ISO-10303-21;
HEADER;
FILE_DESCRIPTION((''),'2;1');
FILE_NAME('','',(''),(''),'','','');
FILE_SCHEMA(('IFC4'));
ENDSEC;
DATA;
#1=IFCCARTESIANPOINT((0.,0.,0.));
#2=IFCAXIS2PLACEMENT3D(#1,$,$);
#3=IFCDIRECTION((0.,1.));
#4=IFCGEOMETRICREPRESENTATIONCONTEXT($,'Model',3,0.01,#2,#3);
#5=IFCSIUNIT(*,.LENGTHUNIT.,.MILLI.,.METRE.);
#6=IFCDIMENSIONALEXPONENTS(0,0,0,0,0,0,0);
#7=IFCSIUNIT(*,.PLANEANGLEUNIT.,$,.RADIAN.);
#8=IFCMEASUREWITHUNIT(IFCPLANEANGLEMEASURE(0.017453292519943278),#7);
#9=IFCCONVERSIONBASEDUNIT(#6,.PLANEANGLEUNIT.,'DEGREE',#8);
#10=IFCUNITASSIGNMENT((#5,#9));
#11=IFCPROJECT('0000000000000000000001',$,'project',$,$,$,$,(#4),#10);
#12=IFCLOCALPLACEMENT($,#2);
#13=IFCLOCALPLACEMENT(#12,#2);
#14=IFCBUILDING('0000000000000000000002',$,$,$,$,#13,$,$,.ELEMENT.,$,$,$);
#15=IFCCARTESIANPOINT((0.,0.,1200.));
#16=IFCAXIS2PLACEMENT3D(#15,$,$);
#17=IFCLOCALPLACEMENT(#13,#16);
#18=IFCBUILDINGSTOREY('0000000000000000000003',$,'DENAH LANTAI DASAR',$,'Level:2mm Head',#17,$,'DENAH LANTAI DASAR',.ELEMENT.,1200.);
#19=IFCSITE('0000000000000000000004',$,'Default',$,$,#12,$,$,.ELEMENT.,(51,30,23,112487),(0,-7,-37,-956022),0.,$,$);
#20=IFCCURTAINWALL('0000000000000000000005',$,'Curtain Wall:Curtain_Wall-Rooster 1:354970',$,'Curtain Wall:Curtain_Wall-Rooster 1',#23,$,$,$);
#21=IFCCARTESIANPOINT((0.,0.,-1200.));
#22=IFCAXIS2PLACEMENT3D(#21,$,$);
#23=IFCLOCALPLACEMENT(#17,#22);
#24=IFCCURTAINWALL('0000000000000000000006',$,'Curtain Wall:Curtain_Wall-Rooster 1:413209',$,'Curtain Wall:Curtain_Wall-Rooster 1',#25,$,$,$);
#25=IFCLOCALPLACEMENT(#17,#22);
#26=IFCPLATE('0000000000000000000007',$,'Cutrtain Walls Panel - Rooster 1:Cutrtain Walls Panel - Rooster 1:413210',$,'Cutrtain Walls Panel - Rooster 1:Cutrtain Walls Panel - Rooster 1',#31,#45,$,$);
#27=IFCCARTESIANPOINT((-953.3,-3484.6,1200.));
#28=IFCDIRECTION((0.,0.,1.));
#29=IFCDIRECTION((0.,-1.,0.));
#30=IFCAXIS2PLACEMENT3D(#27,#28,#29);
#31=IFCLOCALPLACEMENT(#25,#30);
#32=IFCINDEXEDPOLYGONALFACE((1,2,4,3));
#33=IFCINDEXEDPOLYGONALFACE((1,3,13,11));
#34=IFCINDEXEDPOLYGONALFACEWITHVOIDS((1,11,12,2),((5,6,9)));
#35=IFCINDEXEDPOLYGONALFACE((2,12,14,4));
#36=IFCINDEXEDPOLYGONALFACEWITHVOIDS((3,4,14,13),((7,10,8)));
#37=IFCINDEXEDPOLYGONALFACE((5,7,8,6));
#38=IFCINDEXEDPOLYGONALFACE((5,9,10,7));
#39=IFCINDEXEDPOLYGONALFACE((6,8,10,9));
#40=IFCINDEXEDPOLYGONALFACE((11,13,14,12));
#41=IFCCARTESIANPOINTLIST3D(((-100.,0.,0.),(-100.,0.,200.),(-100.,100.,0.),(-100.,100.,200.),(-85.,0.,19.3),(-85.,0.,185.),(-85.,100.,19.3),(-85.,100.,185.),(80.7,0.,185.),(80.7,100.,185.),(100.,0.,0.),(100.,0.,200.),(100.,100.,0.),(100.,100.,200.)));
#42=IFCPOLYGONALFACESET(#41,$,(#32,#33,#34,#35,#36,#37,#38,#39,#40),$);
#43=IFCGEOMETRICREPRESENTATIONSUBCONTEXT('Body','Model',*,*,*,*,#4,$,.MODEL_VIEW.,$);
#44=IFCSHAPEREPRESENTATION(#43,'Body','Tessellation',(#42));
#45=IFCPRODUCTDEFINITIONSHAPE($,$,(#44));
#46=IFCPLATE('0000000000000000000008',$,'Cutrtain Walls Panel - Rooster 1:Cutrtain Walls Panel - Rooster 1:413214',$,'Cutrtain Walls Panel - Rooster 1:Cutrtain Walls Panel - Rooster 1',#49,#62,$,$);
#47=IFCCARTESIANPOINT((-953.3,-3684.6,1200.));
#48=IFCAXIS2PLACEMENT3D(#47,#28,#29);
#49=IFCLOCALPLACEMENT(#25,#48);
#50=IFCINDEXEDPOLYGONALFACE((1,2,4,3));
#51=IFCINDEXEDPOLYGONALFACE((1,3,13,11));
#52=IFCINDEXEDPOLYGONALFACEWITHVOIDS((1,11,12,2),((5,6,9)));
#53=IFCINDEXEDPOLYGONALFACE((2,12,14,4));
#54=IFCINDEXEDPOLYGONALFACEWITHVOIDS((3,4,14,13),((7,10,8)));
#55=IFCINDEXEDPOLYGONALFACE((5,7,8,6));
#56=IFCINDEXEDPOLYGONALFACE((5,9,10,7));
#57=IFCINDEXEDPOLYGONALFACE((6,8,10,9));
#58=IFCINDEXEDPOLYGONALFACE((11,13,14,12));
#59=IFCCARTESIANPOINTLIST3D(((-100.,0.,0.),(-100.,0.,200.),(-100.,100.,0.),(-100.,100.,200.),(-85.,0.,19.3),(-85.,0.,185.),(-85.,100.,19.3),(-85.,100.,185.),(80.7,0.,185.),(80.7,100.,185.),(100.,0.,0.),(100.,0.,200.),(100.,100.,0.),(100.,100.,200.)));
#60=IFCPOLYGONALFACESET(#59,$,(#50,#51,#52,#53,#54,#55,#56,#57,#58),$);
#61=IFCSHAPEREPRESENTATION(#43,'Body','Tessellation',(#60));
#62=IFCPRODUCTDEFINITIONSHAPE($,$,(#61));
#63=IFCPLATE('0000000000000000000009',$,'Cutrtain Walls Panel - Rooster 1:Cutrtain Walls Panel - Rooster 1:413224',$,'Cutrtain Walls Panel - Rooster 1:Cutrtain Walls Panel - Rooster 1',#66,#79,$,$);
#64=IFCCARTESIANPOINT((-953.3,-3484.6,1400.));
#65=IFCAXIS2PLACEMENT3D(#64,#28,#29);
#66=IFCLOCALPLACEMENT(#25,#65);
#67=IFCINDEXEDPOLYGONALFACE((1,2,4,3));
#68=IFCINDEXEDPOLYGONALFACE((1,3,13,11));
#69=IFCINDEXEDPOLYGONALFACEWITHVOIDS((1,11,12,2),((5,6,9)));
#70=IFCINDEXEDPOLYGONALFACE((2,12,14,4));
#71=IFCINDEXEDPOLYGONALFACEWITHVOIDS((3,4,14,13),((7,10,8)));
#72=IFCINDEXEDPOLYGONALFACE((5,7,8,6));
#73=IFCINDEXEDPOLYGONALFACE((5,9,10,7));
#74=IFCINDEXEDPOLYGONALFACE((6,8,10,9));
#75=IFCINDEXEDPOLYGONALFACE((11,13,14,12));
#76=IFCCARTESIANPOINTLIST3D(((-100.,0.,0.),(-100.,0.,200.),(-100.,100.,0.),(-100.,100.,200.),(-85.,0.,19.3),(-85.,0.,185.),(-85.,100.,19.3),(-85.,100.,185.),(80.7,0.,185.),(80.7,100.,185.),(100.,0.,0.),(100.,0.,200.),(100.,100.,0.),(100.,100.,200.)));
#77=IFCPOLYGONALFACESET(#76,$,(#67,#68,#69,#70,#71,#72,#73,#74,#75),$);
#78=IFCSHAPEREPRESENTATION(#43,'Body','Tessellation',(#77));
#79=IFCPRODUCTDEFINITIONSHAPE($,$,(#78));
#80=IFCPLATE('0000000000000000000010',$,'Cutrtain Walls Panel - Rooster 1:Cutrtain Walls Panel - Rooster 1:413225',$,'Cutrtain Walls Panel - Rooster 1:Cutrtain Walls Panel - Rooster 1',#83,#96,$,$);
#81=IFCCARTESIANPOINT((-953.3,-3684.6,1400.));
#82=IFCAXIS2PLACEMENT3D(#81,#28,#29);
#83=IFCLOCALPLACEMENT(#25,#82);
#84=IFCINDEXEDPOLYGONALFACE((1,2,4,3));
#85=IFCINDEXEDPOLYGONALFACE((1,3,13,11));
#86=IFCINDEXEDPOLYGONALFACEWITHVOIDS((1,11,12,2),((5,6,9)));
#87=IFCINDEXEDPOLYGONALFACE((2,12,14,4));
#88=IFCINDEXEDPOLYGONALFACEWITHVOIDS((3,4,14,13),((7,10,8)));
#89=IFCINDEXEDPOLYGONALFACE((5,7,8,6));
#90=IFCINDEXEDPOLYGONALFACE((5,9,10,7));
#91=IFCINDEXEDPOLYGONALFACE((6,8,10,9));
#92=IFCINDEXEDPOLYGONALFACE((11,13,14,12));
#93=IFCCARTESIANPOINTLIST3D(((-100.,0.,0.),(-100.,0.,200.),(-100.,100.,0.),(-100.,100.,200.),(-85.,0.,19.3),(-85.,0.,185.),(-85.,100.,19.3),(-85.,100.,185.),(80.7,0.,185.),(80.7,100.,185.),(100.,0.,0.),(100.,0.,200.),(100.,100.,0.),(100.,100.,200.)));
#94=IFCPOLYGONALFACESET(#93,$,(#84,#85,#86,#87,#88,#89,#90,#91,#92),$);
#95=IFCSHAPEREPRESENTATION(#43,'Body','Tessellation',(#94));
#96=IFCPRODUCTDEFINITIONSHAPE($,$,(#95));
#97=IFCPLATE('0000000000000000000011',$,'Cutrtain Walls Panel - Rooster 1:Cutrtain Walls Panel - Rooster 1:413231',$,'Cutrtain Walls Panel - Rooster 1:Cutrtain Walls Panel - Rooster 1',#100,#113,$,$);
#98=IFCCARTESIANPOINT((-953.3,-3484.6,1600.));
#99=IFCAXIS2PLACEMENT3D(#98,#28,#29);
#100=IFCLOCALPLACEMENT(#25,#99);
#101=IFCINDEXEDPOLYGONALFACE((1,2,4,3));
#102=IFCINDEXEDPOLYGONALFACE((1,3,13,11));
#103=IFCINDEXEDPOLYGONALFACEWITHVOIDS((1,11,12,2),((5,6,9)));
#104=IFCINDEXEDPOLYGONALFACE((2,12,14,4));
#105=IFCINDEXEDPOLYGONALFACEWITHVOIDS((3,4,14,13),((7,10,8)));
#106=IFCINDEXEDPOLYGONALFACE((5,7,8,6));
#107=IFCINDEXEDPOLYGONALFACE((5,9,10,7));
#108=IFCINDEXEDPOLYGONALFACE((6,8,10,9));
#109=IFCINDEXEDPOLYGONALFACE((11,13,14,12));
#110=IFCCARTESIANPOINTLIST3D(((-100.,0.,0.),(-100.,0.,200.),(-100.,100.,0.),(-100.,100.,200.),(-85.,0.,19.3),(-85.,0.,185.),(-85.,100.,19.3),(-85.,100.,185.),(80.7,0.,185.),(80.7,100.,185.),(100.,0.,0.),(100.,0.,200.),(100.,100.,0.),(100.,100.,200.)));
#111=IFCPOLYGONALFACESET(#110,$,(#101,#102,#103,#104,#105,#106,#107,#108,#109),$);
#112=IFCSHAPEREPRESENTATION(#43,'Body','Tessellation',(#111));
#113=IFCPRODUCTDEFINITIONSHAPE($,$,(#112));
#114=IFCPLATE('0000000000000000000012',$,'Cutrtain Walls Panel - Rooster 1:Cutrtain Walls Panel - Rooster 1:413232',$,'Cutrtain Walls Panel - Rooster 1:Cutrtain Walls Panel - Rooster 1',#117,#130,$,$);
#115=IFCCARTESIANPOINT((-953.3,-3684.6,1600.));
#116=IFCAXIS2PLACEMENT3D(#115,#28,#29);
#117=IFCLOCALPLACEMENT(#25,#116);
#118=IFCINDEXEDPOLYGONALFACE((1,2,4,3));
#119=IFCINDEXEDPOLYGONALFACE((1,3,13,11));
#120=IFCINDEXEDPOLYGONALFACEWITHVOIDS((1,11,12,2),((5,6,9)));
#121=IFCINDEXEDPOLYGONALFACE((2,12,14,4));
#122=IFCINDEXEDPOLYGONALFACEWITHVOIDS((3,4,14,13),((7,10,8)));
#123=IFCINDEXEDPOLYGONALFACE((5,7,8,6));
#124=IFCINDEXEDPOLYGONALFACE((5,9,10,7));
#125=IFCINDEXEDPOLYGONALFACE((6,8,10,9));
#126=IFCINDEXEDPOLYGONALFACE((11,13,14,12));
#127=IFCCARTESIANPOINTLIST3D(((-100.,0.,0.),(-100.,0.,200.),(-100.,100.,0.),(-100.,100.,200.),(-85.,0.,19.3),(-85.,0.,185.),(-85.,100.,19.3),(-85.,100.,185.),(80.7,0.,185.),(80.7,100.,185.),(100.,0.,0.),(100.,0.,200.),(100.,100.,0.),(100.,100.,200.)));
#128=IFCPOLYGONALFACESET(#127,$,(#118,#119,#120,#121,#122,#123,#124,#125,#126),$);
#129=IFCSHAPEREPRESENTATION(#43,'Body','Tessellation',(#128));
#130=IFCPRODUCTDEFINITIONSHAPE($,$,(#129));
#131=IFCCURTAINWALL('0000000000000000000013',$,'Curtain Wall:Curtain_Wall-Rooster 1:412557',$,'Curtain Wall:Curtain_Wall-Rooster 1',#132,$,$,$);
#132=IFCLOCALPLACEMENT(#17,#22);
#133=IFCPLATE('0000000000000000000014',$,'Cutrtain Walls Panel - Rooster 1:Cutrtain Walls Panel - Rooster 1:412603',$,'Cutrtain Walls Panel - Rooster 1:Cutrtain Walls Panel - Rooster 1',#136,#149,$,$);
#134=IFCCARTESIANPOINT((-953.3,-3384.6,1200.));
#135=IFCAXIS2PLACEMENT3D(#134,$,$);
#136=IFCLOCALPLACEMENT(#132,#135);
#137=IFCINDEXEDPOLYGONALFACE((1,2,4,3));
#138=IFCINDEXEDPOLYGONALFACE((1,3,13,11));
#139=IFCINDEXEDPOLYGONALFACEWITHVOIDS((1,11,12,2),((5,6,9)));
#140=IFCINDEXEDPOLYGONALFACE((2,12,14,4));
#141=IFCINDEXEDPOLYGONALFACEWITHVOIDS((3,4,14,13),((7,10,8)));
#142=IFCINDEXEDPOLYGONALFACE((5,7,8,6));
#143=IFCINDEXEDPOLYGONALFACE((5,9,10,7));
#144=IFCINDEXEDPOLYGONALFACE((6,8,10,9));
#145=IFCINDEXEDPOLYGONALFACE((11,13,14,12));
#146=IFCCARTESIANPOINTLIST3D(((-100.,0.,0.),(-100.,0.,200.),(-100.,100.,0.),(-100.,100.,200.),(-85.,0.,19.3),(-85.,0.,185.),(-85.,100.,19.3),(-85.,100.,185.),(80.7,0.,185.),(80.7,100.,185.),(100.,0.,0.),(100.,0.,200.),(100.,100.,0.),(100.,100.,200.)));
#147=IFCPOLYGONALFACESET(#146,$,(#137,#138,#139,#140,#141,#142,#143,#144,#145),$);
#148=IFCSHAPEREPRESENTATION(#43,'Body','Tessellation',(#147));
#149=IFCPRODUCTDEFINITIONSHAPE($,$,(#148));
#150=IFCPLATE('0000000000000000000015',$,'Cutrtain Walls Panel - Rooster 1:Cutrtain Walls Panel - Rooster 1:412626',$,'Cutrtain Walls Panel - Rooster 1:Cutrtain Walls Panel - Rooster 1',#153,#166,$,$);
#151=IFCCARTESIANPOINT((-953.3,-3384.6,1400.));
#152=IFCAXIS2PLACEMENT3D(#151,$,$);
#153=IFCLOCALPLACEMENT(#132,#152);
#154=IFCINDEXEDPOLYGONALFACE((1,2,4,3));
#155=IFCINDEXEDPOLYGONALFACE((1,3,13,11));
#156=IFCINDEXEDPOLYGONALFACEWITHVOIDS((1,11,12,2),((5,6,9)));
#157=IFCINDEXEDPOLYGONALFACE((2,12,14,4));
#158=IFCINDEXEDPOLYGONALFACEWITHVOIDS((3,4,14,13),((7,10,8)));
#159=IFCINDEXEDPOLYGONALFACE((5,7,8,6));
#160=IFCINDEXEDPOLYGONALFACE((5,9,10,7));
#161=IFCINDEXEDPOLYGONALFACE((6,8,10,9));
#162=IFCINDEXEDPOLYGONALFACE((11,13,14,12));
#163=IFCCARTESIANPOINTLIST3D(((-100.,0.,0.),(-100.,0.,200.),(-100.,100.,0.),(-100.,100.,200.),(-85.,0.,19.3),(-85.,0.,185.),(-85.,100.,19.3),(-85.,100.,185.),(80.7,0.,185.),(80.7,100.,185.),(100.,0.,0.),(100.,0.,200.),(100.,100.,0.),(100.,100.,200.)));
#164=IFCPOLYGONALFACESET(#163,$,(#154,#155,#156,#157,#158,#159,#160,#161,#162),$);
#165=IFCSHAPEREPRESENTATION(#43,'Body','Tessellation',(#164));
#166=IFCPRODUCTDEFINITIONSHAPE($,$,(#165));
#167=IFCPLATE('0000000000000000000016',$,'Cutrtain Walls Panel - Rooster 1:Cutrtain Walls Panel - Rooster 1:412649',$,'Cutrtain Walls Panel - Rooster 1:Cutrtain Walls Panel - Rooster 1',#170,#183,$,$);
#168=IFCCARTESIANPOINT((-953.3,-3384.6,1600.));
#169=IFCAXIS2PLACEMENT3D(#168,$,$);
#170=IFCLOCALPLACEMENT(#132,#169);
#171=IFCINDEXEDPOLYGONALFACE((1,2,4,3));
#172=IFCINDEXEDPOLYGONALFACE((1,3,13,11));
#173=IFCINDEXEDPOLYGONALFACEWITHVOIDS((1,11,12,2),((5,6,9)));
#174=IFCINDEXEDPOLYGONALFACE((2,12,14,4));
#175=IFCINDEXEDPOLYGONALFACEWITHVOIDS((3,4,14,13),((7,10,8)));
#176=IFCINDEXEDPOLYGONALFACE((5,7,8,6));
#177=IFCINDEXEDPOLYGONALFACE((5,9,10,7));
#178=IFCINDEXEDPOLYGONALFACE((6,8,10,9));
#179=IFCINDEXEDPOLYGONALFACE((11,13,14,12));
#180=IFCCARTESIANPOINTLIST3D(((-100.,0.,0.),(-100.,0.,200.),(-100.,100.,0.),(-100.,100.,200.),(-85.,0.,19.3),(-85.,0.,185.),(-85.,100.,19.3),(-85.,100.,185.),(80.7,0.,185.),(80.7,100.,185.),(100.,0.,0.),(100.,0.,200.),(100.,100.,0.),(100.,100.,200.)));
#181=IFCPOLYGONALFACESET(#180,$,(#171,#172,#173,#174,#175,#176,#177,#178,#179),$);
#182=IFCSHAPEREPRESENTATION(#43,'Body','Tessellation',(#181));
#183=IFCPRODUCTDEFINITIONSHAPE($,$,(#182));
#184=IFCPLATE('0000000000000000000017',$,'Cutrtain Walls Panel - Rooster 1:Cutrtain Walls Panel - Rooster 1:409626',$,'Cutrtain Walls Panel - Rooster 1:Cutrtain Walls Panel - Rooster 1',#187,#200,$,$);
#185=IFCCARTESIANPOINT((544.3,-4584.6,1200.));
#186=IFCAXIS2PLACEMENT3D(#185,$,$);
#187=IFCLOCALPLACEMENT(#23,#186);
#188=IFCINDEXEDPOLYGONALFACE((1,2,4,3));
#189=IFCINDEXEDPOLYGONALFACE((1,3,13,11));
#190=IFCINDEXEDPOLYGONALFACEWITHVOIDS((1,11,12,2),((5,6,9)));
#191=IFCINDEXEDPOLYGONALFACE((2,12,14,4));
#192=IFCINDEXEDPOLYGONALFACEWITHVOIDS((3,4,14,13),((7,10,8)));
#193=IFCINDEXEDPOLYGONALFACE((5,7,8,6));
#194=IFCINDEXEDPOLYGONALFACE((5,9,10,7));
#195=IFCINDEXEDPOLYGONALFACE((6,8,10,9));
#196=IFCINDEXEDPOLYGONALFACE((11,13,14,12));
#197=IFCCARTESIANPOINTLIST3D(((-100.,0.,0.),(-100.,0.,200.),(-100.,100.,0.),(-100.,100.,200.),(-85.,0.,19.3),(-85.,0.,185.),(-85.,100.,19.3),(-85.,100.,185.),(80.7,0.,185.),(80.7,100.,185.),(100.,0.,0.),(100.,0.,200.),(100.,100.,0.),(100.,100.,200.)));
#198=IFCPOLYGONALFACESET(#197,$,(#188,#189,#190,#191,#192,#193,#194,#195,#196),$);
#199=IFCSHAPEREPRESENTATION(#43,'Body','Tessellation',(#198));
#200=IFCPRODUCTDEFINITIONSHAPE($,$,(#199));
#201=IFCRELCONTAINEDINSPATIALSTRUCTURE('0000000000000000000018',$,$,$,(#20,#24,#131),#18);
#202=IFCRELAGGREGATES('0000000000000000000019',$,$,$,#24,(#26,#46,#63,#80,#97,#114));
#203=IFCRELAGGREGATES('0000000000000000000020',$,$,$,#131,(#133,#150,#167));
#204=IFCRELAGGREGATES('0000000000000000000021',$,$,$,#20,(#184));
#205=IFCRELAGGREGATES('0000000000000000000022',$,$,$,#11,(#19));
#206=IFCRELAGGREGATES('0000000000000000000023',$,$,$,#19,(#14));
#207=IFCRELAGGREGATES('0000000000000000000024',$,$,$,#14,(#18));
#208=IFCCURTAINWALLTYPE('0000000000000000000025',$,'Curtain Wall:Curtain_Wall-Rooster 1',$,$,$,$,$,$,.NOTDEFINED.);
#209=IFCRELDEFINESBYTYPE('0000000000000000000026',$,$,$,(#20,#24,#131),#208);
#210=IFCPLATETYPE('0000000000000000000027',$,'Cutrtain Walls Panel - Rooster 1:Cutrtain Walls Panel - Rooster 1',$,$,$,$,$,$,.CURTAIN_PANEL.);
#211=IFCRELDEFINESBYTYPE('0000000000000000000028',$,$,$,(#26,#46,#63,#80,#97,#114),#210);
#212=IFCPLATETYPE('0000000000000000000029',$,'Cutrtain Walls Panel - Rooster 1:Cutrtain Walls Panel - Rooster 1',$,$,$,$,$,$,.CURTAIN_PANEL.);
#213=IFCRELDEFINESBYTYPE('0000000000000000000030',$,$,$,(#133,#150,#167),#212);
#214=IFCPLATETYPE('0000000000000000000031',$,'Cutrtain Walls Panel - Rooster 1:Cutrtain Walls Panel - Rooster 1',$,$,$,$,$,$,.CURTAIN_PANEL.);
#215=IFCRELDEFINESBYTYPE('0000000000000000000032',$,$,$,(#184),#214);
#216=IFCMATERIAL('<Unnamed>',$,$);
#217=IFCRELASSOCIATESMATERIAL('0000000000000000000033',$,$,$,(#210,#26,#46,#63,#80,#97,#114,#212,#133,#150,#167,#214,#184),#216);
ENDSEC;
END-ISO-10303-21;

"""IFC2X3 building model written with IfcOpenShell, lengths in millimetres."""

from ifc_helpers import new_model, entity, si_unit, converted_unit, direction, frame, origin, place, context, subcontext, project, spatial, polyline, outline, extrude, source, transform, mapped, material, type_object, type_shapes, element, aggregate, save


model = new_model("IFC2X3")

# Units and contexts
model_context = context("Model", 3, precision=0.01, world=origin(), true_north=direction((0.0, 1.0)))
body_context = subcontext(model_context, "Body", "Model", "MODEL_VIEW")
ifc_project = project(units=[si_unit("LENGTHUNIT", "METRE", prefix="MILLI"), converted_unit("PLANEANGLEUNIT", "DEGREE", entity("IfcPlaneAngleMeasure", 0.017453292519943278), si_unit("PLANEANGLEUNIT", "RADIAN"), dimensions=[0, 0, 0, 0, 0, 0, 0])], contexts=[model_context])

# Site, building, storey
site_placement = place(None, origin())
site = spatial("IfcSite", under=ifc_project, at=site_placement, Name="Default", CompositionType="ELEMENT", RefLatitude=(51, 30, 23, 112487), RefLongitude=(0, -7, -37, -956022), RefElevation=0.0)
building_placement = place(site_placement, origin())
building = spatial("IfcBuilding", under=site, at=building_placement, CompositionType="ELEMENT")
storey_placement = place(building_placement, frame((0.0, 0.0, 1200.0)))
storey = spatial("IfcBuildingStorey", under=building, at=storey_placement, Name="DENAH LANTAI DASAR", ObjectType="Level:2mm Head", LongName="DENAH LANTAI DASAR", CompositionType="ELEMENT", Elevation=1200.0)

# Curtain wall
curtain_wall_type = type_object("IfcCurtainWallType", Name="Curtain Wall:Curtain_Wall-Rooster 1", PredefinedType="NOTDEFINED")
curtain_wall_1_placement = place(storey_placement, frame((0.0, 0.0, -1200.0)))
curtain_wall_1 = element("IfcCurtainWall", 1, at=curtain_wall_1_placement, inside=storey, type_object=curtain_wall_type, Name="Curtain Wall:Curtain_Wall-Rooster 1:354970", ObjectType="Curtain Wall:Curtain_Wall-Rooster 1")
ifc_material_1 = material(Name="<Unnamed>")
plate_type_1 = type_object("IfcPlateType", Name="Cutrtain Walls Panel - Rooster 1:Cutrtain Walls Panel - Rooster 1", PredefinedType="CURTAIN_PANEL", material=ifc_material_1)
shared_shape_1 = source(origin(), body_context, "Body", "SweptSolid", [
    extrude(outline(polyline([(-100.0, -100.0), (100.0, -100.0), (100.0, 100.0), (-100.0, 100.0), (-100.0, -100.0)]), holes=[polyline([(80.7, 85.0), (-85.0, -80.7), (-85.0, 85.0), (80.7, 85.0)])]), frame((0.0, 0.0, 100.0), z_axis=(0.0, 1.0, 0.0), x_axis=(0.0, 0.0, -1.0)), (0.0, 0.0, 1.0), 100.0),
])
type_shapes(plate_type_1, [shared_shape_1])

# Curtain walls, plates
curtain_wall_2_placement = place(storey_placement, frame((0.0, 0.0, -1200.0)))
curtain_wall_2 = element("IfcCurtainWall", 2, at=curtain_wall_2_placement, inside=storey, type_object=curtain_wall_type, Name="Curtain Wall:Curtain_Wall-Rooster 1:413209", ObjectType="Curtain Wall:Curtain_Wall-Rooster 1")
plate_1_placement = place(curtain_wall_2_placement, frame((-953.3, -3484.6, 1200.0), z_axis=(0.0, 0.0, 1.0), x_axis=(0.0, -1.0, 0.0)))
plate_1 = element("IfcPlate", 3, at=plate_1_placement, type_object=plate_type_1, material=ifc_material_1, Name="Cutrtain Walls Panel - Rooster 1:Cutrtain Walls Panel - Rooster 1:413210", ObjectType="Cutrtain Walls Panel - Rooster 1:Cutrtain Walls Panel - Rooster 1", context=body_context, shape_type="MappedRepresentation", body=[
    mapped(shared_shape_1, transform((0.0, 0.0, 0.0), scale=1.0)),
])
plate_2_placement = place(curtain_wall_2_placement, frame((-953.3, -3684.6, 1200.0), z_axis=(0.0, 0.0, 1.0), x_axis=(0.0, -1.0, 0.0)))
plate_2 = element("IfcPlate", 4, at=plate_2_placement, type_object=plate_type_1, material=ifc_material_1, Name="Cutrtain Walls Panel - Rooster 1:Cutrtain Walls Panel - Rooster 1:413214", ObjectType="Cutrtain Walls Panel - Rooster 1:Cutrtain Walls Panel - Rooster 1", context=body_context, shape_type="MappedRepresentation", body=[
    mapped(shared_shape_1, transform((0.0, 0.0, 0.0), scale=1.0)),
])
plate_3_placement = place(curtain_wall_2_placement, frame((-953.3, -3484.6, 1400.0), z_axis=(0.0, 0.0, 1.0), x_axis=(0.0, -1.0, 0.0)))
plate_3 = element("IfcPlate", 5, at=plate_3_placement, type_object=plate_type_1, material=ifc_material_1, Name="Cutrtain Walls Panel - Rooster 1:Cutrtain Walls Panel - Rooster 1:413224", ObjectType="Cutrtain Walls Panel - Rooster 1:Cutrtain Walls Panel - Rooster 1", context=body_context, shape_type="MappedRepresentation", body=[
    mapped(shared_shape_1, transform((0.0, 0.0, 0.0), scale=1.0)),
])
plate_4_placement = place(curtain_wall_2_placement, frame((-953.3, -3684.6, 1400.0), z_axis=(0.0, 0.0, 1.0), x_axis=(0.0, -1.0, 0.0)))
plate_4 = element("IfcPlate", 6, at=plate_4_placement, type_object=plate_type_1, material=ifc_material_1, Name="Cutrtain Walls Panel - Rooster 1:Cutrtain Walls Panel - Rooster 1:413225", ObjectType="Cutrtain Walls Panel - Rooster 1:Cutrtain Walls Panel - Rooster 1", context=body_context, shape_type="MappedRepresentation", body=[
    mapped(shared_shape_1, transform((0.0, 0.0, 0.0), scale=1.0)),
])
plate_5_placement = place(curtain_wall_2_placement, frame((-953.3, -3484.6, 1600.0), z_axis=(0.0, 0.0, 1.0), x_axis=(0.0, -1.0, 0.0)))
plate_5 = element("IfcPlate", 7, at=plate_5_placement, type_object=plate_type_1, material=ifc_material_1, Name="Cutrtain Walls Panel - Rooster 1:Cutrtain Walls Panel - Rooster 1:413231", ObjectType="Cutrtain Walls Panel - Rooster 1:Cutrtain Walls Panel - Rooster 1", context=body_context, shape_type="MappedRepresentation", body=[
    mapped(shared_shape_1, transform((0.0, 0.0, 0.0), scale=1.0)),
])
plate_6_placement = place(curtain_wall_2_placement, frame((-953.3, -3684.6, 1600.0), z_axis=(0.0, 0.0, 1.0), x_axis=(0.0, -1.0, 0.0)))
plate_6 = element("IfcPlate", 8, at=plate_6_placement, type_object=plate_type_1, material=ifc_material_1, Name="Cutrtain Walls Panel - Rooster 1:Cutrtain Walls Panel - Rooster 1:413232", ObjectType="Cutrtain Walls Panel - Rooster 1:Cutrtain Walls Panel - Rooster 1", context=body_context, shape_type="MappedRepresentation", body=[
    mapped(shared_shape_1, transform((0.0, 0.0, 0.0), scale=1.0)),
])
aggregate(curtain_wall_2, [plate_1, plate_2, plate_3, plate_4, plate_5, plate_6])
curtain_wall_3_placement = place(storey_placement, frame((0.0, 0.0, -1200.0)))
curtain_wall_3 = element("IfcCurtainWall", 9, at=curtain_wall_3_placement, inside=storey, type_object=curtain_wall_type, Name="Curtain Wall:Curtain_Wall-Rooster 1:412557", ObjectType="Curtain Wall:Curtain_Wall-Rooster 1")
plate_type_2 = type_object("IfcPlateType", Name="Cutrtain Walls Panel - Rooster 1:Cutrtain Walls Panel - Rooster 1", PredefinedType="CURTAIN_PANEL", material=ifc_material_1)
shared_shape_2 = source(origin(), body_context, "Body", "SweptSolid", [
    extrude(outline(polyline([(-100.0, -100.0), (100.0, -100.0), (100.0, 100.0), (-100.0, 100.0), (-100.0, -100.0)]), holes=[polyline([(80.7, 85.0), (-85.0, -80.7), (-85.0, 85.0), (80.7, 85.0)])]), frame((0.0, 0.0, 100.0), z_axis=(0.0, 1.0, 0.0), x_axis=(0.0, 0.0, -1.0)), (0.0, 0.0, 1.0), 100.0),
])
type_shapes(plate_type_2, [shared_shape_2])
plate_7_placement = place(curtain_wall_3_placement, frame((-953.3, -3384.6, 1200.0)))
plate_7 = element("IfcPlate", 10, at=plate_7_placement, type_object=plate_type_2, material=ifc_material_1, Name="Cutrtain Walls Panel - Rooster 1:Cutrtain Walls Panel - Rooster 1:412603", ObjectType="Cutrtain Walls Panel - Rooster 1:Cutrtain Walls Panel - Rooster 1", context=body_context, shape_type="MappedRepresentation", body=[
    mapped(shared_shape_2, transform((0.0, 0.0, 0.0), scale=1.0)),
])
plate_8_placement = place(curtain_wall_3_placement, frame((-953.3, -3384.6, 1400.0)))
plate_8 = element("IfcPlate", 11, at=plate_8_placement, type_object=plate_type_2, material=ifc_material_1, Name="Cutrtain Walls Panel - Rooster 1:Cutrtain Walls Panel - Rooster 1:412626", ObjectType="Cutrtain Walls Panel - Rooster 1:Cutrtain Walls Panel - Rooster 1", context=body_context, shape_type="MappedRepresentation", body=[
    mapped(shared_shape_2, transform((0.0, 0.0, 0.0), scale=1.0)),
])
plate_9_placement = place(curtain_wall_3_placement, frame((-953.3, -3384.6, 1600.0)))
plate_9 = element("IfcPlate", 12, at=plate_9_placement, type_object=plate_type_2, material=ifc_material_1, Name="Cutrtain Walls Panel - Rooster 1:Cutrtain Walls Panel - Rooster 1:412649", ObjectType="Cutrtain Walls Panel - Rooster 1:Cutrtain Walls Panel - Rooster 1", context=body_context, shape_type="MappedRepresentation", body=[
    mapped(shared_shape_2, transform((0.0, 0.0, 0.0), scale=1.0)),
])
aggregate(curtain_wall_3, [plate_7, plate_8, plate_9])

# Plate
plate_type_3 = type_object("IfcPlateType", Name="Cutrtain Walls Panel - Rooster 1:Cutrtain Walls Panel - Rooster 1", PredefinedType="CURTAIN_PANEL", material=ifc_material_1)
shared_shape_3 = source(origin(), body_context, "Body", "SweptSolid", [
    extrude(outline(polyline([(-100.0, -100.0), (100.0, -100.0), (100.0, 100.0), (-100.0, 100.0), (-100.0, -100.0)]), holes=[polyline([(80.7, 85.0), (-85.0, -80.7), (-85.0, 85.0), (80.7, 85.0)])]), frame((0.0, 0.0, 100.0), z_axis=(0.0, 1.0, 0.0), x_axis=(0.0, 0.0, -1.0)), (0.0, 0.0, 1.0), 100.0),
])
type_shapes(plate_type_3, [shared_shape_3])
plate_10_placement = place(curtain_wall_1_placement, frame((544.3, -4584.6, 1200.0)))
plate_10 = element("IfcPlate", 13, at=plate_10_placement, type_object=plate_type_3, material=ifc_material_1, Name="Cutrtain Walls Panel - Rooster 1:Cutrtain Walls Panel - Rooster 1:409626", ObjectType="Cutrtain Walls Panel - Rooster 1:Cutrtain Walls Panel - Rooster 1", context=body_context, shape_type="MappedRepresentation", body=[
    mapped(shared_shape_3, transform((0.0, 0.0, 0.0), scale=1.0)),
])
aggregate(curtain_wall_1, [plate_10])

save(model, "model.ifc")
